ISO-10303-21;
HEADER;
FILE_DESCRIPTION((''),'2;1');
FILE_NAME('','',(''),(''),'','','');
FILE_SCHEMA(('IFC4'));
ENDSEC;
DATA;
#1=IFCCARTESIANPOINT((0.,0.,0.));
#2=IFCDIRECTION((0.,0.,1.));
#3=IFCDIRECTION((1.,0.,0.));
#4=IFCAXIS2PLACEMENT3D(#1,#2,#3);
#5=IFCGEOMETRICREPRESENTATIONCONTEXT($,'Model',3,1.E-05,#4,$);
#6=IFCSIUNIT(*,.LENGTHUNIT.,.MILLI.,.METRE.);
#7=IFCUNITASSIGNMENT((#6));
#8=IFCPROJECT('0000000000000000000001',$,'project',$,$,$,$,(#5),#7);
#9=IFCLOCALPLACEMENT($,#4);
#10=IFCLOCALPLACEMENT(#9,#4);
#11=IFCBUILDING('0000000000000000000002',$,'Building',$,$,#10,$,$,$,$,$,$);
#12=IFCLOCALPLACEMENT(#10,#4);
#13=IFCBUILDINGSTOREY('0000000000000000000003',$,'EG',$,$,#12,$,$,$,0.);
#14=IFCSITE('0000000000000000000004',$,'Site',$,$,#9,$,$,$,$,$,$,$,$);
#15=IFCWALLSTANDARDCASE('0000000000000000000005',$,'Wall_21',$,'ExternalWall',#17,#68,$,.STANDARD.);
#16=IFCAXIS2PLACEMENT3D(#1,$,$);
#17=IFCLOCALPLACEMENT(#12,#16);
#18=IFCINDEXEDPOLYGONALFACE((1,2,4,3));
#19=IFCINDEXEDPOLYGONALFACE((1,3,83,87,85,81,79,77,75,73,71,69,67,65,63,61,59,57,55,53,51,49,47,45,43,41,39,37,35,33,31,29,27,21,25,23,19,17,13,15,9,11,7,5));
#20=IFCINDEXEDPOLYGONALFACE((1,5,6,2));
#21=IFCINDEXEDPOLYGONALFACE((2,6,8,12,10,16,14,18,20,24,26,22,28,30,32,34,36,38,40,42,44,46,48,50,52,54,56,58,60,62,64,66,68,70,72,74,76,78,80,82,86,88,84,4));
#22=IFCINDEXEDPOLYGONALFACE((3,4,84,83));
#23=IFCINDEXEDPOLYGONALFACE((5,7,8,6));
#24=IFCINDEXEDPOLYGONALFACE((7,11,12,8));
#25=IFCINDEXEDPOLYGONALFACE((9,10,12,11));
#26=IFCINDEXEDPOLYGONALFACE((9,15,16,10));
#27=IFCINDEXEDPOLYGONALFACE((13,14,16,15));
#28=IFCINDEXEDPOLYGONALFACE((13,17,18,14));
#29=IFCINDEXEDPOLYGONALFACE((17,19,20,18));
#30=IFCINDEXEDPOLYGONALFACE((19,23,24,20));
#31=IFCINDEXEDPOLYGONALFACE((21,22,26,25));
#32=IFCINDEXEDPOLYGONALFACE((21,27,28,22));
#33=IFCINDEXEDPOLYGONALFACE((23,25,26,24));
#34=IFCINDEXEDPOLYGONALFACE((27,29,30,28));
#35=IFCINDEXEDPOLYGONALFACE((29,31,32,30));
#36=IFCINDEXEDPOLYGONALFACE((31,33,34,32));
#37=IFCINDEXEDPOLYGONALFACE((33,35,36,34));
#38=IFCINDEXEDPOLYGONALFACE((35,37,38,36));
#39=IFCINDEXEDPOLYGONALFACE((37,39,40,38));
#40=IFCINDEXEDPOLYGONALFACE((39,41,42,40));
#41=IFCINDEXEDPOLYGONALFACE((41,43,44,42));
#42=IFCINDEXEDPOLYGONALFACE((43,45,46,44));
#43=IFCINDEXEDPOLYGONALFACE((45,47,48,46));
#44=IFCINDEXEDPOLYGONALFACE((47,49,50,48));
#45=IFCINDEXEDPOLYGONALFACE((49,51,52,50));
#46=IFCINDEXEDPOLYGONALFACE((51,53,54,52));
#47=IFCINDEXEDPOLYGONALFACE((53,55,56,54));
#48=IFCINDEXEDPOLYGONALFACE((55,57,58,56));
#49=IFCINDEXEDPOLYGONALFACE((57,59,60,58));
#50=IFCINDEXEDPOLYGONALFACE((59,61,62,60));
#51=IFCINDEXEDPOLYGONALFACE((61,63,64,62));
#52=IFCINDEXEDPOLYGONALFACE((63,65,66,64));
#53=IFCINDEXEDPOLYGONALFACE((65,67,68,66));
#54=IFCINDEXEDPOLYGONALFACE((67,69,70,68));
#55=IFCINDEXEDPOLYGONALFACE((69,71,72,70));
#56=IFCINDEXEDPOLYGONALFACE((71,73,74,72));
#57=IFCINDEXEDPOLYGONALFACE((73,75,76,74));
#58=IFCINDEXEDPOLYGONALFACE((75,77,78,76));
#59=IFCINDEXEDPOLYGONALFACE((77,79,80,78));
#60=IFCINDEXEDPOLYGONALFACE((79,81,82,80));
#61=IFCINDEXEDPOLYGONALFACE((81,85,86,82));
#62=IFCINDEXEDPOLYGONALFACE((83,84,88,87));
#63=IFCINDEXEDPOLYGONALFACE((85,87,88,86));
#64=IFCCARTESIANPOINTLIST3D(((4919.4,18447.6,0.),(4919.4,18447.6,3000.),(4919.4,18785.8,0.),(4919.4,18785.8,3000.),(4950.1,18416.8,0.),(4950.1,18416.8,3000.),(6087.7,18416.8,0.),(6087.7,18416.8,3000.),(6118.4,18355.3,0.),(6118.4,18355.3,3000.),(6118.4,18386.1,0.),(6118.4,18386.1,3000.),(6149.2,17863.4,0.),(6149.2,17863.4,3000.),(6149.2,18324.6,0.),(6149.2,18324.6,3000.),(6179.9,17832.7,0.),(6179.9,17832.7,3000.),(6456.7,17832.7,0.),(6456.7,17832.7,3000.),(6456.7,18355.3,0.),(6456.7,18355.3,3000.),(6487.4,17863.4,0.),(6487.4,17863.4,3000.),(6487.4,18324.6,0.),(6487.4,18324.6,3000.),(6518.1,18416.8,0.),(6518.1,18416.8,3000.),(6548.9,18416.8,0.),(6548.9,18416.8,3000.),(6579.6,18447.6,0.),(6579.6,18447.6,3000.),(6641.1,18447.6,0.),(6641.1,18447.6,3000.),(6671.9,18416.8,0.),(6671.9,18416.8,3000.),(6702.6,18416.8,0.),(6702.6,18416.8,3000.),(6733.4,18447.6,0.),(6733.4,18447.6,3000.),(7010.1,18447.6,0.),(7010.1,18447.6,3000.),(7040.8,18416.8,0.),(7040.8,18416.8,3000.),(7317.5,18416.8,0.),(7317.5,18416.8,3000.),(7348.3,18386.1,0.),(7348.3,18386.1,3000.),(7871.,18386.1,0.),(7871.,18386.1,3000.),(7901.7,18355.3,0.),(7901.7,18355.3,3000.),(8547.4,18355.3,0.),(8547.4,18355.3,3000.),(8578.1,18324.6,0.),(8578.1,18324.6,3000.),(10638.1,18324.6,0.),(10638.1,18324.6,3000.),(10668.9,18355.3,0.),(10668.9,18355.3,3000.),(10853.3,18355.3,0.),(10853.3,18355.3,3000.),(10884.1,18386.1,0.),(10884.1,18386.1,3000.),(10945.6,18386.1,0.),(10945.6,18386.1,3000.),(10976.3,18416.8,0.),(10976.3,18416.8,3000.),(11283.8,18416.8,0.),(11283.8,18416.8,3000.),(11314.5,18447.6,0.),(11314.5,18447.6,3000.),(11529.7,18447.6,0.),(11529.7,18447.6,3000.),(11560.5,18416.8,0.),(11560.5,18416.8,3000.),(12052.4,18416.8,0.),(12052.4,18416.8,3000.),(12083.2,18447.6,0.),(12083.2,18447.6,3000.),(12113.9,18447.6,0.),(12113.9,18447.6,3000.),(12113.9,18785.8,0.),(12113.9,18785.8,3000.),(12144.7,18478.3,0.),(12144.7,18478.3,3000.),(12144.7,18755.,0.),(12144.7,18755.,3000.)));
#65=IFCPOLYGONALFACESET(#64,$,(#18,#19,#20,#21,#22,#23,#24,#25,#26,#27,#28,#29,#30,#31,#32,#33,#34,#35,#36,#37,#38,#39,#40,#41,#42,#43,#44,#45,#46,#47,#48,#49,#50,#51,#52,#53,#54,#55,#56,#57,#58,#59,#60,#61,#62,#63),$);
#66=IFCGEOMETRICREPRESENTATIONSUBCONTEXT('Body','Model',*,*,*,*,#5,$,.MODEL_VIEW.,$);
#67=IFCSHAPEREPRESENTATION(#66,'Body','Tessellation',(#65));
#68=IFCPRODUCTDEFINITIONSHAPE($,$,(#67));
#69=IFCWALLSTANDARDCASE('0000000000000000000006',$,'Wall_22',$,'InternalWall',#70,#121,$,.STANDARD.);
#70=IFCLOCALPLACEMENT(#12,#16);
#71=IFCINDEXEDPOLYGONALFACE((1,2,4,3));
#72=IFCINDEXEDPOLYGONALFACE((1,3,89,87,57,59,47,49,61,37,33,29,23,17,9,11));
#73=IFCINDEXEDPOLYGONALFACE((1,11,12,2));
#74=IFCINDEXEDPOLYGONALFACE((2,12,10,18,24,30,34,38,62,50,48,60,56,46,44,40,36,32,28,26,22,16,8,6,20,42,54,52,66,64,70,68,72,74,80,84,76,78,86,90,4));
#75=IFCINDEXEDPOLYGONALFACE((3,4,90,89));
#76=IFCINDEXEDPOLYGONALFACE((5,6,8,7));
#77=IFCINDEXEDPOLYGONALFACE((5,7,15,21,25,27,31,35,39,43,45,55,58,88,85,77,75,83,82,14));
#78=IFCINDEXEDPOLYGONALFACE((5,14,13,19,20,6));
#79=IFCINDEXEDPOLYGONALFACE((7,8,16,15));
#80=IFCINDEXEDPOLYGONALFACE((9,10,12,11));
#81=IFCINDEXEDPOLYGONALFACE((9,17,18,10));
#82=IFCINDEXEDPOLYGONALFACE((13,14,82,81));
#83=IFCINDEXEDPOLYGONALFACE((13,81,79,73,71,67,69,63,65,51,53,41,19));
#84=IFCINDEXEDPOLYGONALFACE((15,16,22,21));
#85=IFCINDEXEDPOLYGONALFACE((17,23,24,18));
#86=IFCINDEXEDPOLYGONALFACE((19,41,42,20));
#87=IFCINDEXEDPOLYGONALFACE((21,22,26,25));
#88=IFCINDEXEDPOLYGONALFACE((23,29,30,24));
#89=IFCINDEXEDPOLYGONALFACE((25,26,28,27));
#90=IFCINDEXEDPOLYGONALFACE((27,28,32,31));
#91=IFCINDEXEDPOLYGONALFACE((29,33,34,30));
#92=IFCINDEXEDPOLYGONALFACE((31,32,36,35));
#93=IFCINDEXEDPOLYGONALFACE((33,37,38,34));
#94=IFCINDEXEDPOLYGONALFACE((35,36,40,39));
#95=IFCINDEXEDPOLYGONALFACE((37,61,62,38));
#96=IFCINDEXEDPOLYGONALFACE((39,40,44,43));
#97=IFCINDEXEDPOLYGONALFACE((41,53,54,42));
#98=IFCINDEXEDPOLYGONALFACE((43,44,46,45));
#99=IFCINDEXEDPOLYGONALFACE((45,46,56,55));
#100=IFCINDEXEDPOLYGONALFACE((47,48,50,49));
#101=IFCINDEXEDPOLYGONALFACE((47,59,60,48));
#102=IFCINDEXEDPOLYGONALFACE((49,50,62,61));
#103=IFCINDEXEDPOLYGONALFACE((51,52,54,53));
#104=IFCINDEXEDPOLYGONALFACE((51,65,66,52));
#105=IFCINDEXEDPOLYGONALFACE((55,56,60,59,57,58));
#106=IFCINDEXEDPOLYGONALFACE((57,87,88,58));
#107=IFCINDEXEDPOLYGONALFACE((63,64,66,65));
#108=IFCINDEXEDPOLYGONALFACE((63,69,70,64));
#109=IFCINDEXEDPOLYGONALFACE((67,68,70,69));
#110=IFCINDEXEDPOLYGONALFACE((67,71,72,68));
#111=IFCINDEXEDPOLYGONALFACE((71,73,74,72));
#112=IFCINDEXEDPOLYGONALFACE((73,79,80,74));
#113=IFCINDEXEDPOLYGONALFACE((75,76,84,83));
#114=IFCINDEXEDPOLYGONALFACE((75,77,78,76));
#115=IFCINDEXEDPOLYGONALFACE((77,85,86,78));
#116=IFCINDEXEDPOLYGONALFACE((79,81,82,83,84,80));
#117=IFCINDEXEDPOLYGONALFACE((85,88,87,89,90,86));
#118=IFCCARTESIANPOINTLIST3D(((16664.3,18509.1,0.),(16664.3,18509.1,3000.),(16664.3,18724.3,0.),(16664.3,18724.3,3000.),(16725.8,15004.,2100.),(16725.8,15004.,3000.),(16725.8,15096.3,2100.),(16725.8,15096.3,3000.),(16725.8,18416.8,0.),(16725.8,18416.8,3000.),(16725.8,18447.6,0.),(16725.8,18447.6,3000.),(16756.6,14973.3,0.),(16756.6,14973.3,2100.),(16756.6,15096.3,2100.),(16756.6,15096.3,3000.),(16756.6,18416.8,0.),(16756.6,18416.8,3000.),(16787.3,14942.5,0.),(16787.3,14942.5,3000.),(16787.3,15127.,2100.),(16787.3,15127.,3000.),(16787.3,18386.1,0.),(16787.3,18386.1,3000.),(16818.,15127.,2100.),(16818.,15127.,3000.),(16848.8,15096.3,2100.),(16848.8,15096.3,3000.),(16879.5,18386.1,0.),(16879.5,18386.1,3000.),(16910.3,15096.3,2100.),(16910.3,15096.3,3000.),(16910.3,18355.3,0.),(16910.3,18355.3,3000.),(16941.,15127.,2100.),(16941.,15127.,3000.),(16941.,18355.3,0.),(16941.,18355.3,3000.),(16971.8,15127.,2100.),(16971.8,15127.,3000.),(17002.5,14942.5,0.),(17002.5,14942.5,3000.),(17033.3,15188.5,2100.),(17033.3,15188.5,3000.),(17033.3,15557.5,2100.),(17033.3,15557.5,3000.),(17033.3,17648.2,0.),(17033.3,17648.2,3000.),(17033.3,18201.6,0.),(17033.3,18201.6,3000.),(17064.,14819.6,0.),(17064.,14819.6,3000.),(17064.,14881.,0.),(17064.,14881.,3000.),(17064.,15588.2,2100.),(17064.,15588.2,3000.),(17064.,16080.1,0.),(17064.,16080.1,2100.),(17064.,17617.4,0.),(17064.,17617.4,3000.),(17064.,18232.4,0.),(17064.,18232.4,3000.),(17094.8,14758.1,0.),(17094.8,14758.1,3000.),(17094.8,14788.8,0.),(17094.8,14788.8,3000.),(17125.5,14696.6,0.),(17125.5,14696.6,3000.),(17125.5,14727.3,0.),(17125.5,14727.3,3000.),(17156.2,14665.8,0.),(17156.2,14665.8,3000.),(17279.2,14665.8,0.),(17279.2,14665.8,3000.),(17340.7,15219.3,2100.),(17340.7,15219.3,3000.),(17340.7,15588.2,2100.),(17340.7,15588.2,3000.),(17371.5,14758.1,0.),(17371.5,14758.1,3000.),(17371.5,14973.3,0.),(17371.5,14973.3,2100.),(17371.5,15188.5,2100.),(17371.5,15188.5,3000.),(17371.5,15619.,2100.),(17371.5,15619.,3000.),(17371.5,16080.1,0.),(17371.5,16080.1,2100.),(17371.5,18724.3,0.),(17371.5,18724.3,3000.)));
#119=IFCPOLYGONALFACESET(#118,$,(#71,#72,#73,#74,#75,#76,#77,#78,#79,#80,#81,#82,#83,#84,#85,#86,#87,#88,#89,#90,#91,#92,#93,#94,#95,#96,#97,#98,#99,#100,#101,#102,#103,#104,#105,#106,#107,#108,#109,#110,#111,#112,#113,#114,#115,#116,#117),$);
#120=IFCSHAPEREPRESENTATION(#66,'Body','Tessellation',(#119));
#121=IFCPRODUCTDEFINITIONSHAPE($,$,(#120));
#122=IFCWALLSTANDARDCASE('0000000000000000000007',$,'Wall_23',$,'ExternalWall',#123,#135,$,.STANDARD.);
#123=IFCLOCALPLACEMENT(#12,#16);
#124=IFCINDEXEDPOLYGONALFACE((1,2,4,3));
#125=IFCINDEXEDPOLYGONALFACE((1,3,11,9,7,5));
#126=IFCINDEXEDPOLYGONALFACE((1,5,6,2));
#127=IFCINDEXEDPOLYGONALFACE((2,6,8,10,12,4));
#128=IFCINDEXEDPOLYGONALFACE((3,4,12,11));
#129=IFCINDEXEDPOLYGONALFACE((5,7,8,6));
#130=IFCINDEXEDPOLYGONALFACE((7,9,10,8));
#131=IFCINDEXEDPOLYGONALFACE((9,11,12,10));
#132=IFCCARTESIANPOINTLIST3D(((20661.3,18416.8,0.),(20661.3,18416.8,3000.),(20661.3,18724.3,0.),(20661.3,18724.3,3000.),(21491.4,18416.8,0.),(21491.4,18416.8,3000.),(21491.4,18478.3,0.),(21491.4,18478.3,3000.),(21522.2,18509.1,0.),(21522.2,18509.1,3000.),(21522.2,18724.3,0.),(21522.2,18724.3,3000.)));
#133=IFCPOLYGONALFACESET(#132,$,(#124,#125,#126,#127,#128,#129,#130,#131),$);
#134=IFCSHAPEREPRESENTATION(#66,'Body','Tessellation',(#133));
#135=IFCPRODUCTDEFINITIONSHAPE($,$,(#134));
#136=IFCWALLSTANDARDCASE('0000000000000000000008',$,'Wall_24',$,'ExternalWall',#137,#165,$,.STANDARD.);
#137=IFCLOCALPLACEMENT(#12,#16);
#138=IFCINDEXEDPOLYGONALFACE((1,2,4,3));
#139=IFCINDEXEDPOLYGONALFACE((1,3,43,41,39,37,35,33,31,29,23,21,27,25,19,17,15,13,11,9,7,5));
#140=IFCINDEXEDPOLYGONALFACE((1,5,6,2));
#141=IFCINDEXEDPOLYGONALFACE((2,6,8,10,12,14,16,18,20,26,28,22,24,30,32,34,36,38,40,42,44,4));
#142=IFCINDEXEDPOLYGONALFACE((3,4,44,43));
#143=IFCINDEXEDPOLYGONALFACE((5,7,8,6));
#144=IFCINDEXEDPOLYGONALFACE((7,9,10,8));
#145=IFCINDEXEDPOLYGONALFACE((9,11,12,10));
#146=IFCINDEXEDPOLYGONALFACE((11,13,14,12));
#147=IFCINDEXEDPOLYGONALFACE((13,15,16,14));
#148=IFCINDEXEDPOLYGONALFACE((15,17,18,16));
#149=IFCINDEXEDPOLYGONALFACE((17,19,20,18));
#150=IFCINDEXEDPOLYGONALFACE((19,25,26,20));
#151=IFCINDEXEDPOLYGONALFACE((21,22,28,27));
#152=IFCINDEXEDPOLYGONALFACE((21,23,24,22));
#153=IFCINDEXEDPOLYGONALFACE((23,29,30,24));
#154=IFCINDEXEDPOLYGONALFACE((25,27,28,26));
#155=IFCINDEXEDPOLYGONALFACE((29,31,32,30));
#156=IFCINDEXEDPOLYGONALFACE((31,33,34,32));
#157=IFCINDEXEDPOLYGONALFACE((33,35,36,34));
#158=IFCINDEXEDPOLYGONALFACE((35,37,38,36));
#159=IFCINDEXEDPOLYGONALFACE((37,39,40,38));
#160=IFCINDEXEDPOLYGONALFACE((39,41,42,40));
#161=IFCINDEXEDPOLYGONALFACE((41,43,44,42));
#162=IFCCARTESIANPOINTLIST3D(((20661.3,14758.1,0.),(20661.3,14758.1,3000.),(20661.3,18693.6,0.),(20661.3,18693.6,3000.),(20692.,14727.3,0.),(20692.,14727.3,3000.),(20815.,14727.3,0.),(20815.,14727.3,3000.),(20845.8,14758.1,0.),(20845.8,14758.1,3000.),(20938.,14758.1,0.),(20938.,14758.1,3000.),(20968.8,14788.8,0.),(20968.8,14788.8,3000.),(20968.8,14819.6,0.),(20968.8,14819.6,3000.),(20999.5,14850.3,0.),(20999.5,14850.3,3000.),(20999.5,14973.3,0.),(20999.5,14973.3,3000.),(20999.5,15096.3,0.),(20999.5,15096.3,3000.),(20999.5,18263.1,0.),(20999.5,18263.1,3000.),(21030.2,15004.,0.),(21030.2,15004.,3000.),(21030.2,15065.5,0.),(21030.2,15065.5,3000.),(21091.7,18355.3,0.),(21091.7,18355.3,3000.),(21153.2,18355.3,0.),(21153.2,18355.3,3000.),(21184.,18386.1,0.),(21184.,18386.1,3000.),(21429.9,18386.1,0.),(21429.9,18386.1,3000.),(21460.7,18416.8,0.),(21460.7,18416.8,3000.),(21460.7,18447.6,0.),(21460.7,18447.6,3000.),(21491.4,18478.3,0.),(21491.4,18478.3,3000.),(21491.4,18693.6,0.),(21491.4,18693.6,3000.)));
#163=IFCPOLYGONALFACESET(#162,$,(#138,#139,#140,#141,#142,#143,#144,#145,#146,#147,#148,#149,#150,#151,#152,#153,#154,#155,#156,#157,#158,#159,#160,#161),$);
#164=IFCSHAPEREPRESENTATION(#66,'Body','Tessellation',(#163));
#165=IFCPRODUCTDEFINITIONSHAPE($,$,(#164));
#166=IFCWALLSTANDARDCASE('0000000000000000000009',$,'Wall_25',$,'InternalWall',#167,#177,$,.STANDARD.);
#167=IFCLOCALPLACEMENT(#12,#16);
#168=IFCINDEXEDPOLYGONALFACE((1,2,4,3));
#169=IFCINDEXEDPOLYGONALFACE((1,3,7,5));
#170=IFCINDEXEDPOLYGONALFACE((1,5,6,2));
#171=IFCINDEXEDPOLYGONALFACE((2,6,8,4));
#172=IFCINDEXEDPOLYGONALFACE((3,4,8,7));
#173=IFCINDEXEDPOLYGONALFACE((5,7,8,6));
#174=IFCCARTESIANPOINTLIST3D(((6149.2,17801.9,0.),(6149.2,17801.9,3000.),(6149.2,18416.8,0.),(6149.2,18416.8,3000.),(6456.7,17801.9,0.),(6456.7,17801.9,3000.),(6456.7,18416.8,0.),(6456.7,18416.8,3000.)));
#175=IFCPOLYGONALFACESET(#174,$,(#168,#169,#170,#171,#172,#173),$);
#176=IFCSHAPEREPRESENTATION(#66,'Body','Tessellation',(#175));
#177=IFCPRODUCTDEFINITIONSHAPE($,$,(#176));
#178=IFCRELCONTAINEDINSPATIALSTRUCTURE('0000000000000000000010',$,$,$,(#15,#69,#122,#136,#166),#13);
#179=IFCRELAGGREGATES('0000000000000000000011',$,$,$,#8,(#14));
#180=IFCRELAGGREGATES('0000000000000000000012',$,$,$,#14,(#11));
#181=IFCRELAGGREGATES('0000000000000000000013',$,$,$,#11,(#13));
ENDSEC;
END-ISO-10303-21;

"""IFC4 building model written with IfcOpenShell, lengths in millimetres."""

from ifc_helpers import new_model, si_unit, frame, origin_with_axes, place, context, subcontext, project, spatial, polyline, rectangle, outline, extrude, element, save


model = new_model("IFC4")

# Units and contexts
model_context = context("Model", 3, precision=1e-05, world=origin_with_axes())
body_context = subcontext(model_context, "Body", "Model", "MODEL_VIEW")
ifc_project = project(units=[si_unit("LENGTHUNIT", "METRE", prefix="MILLI")], contexts=[model_context])

# Site, building, storey
site_placement = place(None, origin_with_axes())
site = spatial("IfcSite", under=ifc_project, at=site_placement, Name="Site")
building_placement = place(site_placement, origin_with_axes())
building = spatial("IfcBuilding", under=site, at=building_placement, Name="Building")
storey_placement = place(building_placement, origin_with_axes())
storey = spatial("IfcBuildingStorey", under=building, at=storey_placement, Name="EG", Elevation=0.0)

# Wall
wall_1_placement = place(storey_placement, origin_with_axes())
element("IfcWallStandardCase", 1, at=wall_1_placement, inside=storey, Name="Wall_21", ObjectType="ExternalWall", PredefinedType="STANDARD", context=body_context, shape_type="SweptSolid", body=[
    extrude(outline(polyline([(6179.9, 17832.7, 0.0), (6149.2, 17863.4, 0.0), (6149.2, 18324.6, 0.0), (6118.4, 18355.3, 0.0), (6118.4, 18386.1, 0.0), (6087.7, 18416.8, 0.0), (4950.1, 18416.8, 0.0), (4919.4, 18447.6, 0.0), (4919.4, 18785.8, 0.0), (12113.9, 18785.8, 0.0), (12144.7, 18755.0, 0.0), (12144.7, 18478.3, 0.0), (12113.9, 18447.6, 0.0), (12083.2, 18447.6, 0.0), (12052.4, 18416.8, 0.0), (11560.5, 18416.8, 0.0), (11529.7, 18447.6, 0.0), (11314.5, 18447.6, 0.0), (11283.8, 18416.8, 0.0), (10976.3, 18416.8, 0.0), (10945.6, 18386.1, 0.0), (10884.1, 18386.1, 0.0), (10853.3, 18355.3, 0.0), (10668.9, 18355.3, 0.0), (10638.1, 18324.6, 0.0), (8578.1, 18324.6, 0.0), (8547.4, 18355.3, 0.0), (7901.7, 18355.3, 0.0), (7871.0, 18386.1, 0.0), (7348.3, 18386.1, 0.0), (7317.5, 18416.8, 0.0), (7040.8, 18416.8, 0.0), (7010.1, 18447.6, 0.0), (6733.4, 18447.6, 0.0), (6702.6, 18416.8, 0.0), (6671.9, 18416.8, 0.0), (6641.1, 18447.6, 0.0), (6579.6, 18447.6, 0.0), (6548.9, 18416.8, 0.0), (6518.1, 18416.8, 0.0), (6456.7, 18355.3, 0.0), (6487.4, 18324.6, 0.0), (6487.4, 17863.4, 0.0), (6456.7, 17832.7, 0.0), (6179.9, 17832.7, 0.0)])), origin_with_axes(), (0.0, 0.0, 1.0), 3000.0),
])

# Wall, opening
wall_2_placement = place(storey_placement, origin_with_axes())
wall_2 = element("IfcWallStandardCase", 2, at=wall_2_placement, inside=storey, Name="Wall_22", ObjectType="InternalWall", PredefinedType="STANDARD", context=body_context, shape_type="SweptSolid", body=[
    extrude(outline(polyline([(17156.2, 14665.8, 0.0), (17125.5, 14696.6, 0.0), (17125.5, 14727.3, 0.0), (17094.8, 14758.1, 0.0), (17094.8, 14788.8, 0.0), (17064.0, 14819.6, 0.0), (17064.0, 14881.0, 0.0), (17002.5, 14942.5, 0.0), (16787.3, 14942.5, 0.0), (16725.8, 15004.0, 0.0), (16725.8, 15096.3, 0.0), (16756.6, 15096.3, 0.0), (16787.3, 15127.0, 0.0), (16818.0, 15127.0, 0.0), (16848.8, 15096.3, 0.0), (16910.3, 15096.3, 0.0), (16941.0, 15127.0, 0.0), (16971.8, 15127.0, 0.0), (17033.3, 15188.5, 0.0), (17033.3, 15557.5, 0.0), (17064.0, 15588.2, 0.0), (17064.0, 17617.4, 0.0), (17033.3, 17648.2, 0.0), (17033.3, 18201.6, 0.0), (17064.0, 18232.4, 0.0), (16941.0, 18355.3, 0.0), (16910.3, 18355.3, 0.0), (16879.5, 18386.1, 0.0), (16787.3, 18386.1, 0.0), (16756.6, 18416.8, 0.0), (16725.8, 18416.8, 0.0), (16725.8, 18447.6, 0.0), (16664.3, 18509.1, 0.0), (16664.3, 18724.3, 0.0), (17371.5, 18724.3, 0.0), (17371.5, 15619.0, 0.0), (17340.7, 15588.2, 0.0), (17340.7, 15219.3, 0.0), (17371.5, 15188.5, 0.0), (17371.5, 14758.1, 0.0), (17279.2, 14665.8, 0.0), (17156.2, 14665.8, 0.0)])), origin_with_axes(), (0.0, 0.0, 1.0), 3000.0),
])
opening_1_placement = place(wall_2_placement, origin_with_axes())
element("IfcOpeningElement", 3, at=opening_1_placement, inside=storey, cuts=wall_2, context=body_context, shape_type="SweptSolid", body=[
    extrude(rectangle(XDim=1106.9, YDim=707.2), frame((17017.9, 15526.7, 0.0), z_axis=(0.0, 0.0, 1.0), x_axis=(0.0, 1.0, 0.0)), (0.0, 0.0, 1.0), 2100.0),
])

# Walls
wall_3_placement = place(storey_placement, origin_with_axes())
element("IfcWallStandardCase", 4, at=wall_3_placement, inside=storey, Name="Wall_23", ObjectType="ExternalWall", PredefinedType="STANDARD", context=body_context, shape_type="SweptSolid", body=[
    extrude(outline(polyline([(20661.3, 18416.8, 0.0), (20661.3, 18724.3, 0.0), (21522.2, 18724.3, 0.0), (21522.2, 18509.1, 0.0), (21491.4, 18478.3, 0.0), (21491.4, 18416.8, 0.0), (20661.3, 18416.8, 0.0)])), origin_with_axes(), (0.0, 0.0, 1.0), 3000.0),
])
wall_4_placement = place(storey_placement, origin_with_axes())
element("IfcWallStandardCase", 5, at=wall_4_placement, inside=storey, Name="Wall_24", ObjectType="ExternalWall", PredefinedType="STANDARD", context=body_context, shape_type="SweptSolid", body=[
    extrude(outline(polyline([(20692.0, 14727.3, 0.0), (20661.3, 14758.1, 0.0), (20661.3, 18693.6, 0.0), (21491.4, 18693.6, 0.0), (21491.4, 18478.3, 0.0), (21460.7, 18447.6, 0.0), (21460.7, 18416.8, 0.0), (21429.9, 18386.1, 0.0), (21184.0, 18386.1, 0.0), (21153.2, 18355.3, 0.0), (21091.7, 18355.3, 0.0), (20999.5, 18263.1, 0.0), (20999.5, 15096.3, 0.0), (21030.2, 15065.5, 0.0), (21030.2, 15004.0, 0.0), (20999.5, 14973.3, 0.0), (20999.5, 14850.3, 0.0), (20968.8, 14819.6, 0.0), (20968.8, 14788.8, 0.0), (20938.0, 14758.1, 0.0), (20845.8, 14758.1, 0.0), (20815.0, 14727.3, 0.0), (20692.0, 14727.3, 0.0)])), origin_with_axes(), (0.0, 0.0, 1.0), 3000.0),
])
wall_5_placement = place(storey_placement, origin_with_axes())
element("IfcWallStandardCase", 6, at=wall_5_placement, inside=storey, Name="Wall_25", ObjectType="InternalWall", PredefinedType="STANDARD", context=body_context, shape_type="SweptSolid", body=[
    extrude(outline(polyline([(6149.2, 17801.9, 0.0), (6149.2, 18416.8, 0.0), (6456.7, 18416.8, 0.0), (6456.7, 17801.9, 0.0), (6149.2, 17801.9, 0.0)])), origin_with_axes(), (0.0, 0.0, 1.0), 3000.0),
])

save(model, "model.ifc")
